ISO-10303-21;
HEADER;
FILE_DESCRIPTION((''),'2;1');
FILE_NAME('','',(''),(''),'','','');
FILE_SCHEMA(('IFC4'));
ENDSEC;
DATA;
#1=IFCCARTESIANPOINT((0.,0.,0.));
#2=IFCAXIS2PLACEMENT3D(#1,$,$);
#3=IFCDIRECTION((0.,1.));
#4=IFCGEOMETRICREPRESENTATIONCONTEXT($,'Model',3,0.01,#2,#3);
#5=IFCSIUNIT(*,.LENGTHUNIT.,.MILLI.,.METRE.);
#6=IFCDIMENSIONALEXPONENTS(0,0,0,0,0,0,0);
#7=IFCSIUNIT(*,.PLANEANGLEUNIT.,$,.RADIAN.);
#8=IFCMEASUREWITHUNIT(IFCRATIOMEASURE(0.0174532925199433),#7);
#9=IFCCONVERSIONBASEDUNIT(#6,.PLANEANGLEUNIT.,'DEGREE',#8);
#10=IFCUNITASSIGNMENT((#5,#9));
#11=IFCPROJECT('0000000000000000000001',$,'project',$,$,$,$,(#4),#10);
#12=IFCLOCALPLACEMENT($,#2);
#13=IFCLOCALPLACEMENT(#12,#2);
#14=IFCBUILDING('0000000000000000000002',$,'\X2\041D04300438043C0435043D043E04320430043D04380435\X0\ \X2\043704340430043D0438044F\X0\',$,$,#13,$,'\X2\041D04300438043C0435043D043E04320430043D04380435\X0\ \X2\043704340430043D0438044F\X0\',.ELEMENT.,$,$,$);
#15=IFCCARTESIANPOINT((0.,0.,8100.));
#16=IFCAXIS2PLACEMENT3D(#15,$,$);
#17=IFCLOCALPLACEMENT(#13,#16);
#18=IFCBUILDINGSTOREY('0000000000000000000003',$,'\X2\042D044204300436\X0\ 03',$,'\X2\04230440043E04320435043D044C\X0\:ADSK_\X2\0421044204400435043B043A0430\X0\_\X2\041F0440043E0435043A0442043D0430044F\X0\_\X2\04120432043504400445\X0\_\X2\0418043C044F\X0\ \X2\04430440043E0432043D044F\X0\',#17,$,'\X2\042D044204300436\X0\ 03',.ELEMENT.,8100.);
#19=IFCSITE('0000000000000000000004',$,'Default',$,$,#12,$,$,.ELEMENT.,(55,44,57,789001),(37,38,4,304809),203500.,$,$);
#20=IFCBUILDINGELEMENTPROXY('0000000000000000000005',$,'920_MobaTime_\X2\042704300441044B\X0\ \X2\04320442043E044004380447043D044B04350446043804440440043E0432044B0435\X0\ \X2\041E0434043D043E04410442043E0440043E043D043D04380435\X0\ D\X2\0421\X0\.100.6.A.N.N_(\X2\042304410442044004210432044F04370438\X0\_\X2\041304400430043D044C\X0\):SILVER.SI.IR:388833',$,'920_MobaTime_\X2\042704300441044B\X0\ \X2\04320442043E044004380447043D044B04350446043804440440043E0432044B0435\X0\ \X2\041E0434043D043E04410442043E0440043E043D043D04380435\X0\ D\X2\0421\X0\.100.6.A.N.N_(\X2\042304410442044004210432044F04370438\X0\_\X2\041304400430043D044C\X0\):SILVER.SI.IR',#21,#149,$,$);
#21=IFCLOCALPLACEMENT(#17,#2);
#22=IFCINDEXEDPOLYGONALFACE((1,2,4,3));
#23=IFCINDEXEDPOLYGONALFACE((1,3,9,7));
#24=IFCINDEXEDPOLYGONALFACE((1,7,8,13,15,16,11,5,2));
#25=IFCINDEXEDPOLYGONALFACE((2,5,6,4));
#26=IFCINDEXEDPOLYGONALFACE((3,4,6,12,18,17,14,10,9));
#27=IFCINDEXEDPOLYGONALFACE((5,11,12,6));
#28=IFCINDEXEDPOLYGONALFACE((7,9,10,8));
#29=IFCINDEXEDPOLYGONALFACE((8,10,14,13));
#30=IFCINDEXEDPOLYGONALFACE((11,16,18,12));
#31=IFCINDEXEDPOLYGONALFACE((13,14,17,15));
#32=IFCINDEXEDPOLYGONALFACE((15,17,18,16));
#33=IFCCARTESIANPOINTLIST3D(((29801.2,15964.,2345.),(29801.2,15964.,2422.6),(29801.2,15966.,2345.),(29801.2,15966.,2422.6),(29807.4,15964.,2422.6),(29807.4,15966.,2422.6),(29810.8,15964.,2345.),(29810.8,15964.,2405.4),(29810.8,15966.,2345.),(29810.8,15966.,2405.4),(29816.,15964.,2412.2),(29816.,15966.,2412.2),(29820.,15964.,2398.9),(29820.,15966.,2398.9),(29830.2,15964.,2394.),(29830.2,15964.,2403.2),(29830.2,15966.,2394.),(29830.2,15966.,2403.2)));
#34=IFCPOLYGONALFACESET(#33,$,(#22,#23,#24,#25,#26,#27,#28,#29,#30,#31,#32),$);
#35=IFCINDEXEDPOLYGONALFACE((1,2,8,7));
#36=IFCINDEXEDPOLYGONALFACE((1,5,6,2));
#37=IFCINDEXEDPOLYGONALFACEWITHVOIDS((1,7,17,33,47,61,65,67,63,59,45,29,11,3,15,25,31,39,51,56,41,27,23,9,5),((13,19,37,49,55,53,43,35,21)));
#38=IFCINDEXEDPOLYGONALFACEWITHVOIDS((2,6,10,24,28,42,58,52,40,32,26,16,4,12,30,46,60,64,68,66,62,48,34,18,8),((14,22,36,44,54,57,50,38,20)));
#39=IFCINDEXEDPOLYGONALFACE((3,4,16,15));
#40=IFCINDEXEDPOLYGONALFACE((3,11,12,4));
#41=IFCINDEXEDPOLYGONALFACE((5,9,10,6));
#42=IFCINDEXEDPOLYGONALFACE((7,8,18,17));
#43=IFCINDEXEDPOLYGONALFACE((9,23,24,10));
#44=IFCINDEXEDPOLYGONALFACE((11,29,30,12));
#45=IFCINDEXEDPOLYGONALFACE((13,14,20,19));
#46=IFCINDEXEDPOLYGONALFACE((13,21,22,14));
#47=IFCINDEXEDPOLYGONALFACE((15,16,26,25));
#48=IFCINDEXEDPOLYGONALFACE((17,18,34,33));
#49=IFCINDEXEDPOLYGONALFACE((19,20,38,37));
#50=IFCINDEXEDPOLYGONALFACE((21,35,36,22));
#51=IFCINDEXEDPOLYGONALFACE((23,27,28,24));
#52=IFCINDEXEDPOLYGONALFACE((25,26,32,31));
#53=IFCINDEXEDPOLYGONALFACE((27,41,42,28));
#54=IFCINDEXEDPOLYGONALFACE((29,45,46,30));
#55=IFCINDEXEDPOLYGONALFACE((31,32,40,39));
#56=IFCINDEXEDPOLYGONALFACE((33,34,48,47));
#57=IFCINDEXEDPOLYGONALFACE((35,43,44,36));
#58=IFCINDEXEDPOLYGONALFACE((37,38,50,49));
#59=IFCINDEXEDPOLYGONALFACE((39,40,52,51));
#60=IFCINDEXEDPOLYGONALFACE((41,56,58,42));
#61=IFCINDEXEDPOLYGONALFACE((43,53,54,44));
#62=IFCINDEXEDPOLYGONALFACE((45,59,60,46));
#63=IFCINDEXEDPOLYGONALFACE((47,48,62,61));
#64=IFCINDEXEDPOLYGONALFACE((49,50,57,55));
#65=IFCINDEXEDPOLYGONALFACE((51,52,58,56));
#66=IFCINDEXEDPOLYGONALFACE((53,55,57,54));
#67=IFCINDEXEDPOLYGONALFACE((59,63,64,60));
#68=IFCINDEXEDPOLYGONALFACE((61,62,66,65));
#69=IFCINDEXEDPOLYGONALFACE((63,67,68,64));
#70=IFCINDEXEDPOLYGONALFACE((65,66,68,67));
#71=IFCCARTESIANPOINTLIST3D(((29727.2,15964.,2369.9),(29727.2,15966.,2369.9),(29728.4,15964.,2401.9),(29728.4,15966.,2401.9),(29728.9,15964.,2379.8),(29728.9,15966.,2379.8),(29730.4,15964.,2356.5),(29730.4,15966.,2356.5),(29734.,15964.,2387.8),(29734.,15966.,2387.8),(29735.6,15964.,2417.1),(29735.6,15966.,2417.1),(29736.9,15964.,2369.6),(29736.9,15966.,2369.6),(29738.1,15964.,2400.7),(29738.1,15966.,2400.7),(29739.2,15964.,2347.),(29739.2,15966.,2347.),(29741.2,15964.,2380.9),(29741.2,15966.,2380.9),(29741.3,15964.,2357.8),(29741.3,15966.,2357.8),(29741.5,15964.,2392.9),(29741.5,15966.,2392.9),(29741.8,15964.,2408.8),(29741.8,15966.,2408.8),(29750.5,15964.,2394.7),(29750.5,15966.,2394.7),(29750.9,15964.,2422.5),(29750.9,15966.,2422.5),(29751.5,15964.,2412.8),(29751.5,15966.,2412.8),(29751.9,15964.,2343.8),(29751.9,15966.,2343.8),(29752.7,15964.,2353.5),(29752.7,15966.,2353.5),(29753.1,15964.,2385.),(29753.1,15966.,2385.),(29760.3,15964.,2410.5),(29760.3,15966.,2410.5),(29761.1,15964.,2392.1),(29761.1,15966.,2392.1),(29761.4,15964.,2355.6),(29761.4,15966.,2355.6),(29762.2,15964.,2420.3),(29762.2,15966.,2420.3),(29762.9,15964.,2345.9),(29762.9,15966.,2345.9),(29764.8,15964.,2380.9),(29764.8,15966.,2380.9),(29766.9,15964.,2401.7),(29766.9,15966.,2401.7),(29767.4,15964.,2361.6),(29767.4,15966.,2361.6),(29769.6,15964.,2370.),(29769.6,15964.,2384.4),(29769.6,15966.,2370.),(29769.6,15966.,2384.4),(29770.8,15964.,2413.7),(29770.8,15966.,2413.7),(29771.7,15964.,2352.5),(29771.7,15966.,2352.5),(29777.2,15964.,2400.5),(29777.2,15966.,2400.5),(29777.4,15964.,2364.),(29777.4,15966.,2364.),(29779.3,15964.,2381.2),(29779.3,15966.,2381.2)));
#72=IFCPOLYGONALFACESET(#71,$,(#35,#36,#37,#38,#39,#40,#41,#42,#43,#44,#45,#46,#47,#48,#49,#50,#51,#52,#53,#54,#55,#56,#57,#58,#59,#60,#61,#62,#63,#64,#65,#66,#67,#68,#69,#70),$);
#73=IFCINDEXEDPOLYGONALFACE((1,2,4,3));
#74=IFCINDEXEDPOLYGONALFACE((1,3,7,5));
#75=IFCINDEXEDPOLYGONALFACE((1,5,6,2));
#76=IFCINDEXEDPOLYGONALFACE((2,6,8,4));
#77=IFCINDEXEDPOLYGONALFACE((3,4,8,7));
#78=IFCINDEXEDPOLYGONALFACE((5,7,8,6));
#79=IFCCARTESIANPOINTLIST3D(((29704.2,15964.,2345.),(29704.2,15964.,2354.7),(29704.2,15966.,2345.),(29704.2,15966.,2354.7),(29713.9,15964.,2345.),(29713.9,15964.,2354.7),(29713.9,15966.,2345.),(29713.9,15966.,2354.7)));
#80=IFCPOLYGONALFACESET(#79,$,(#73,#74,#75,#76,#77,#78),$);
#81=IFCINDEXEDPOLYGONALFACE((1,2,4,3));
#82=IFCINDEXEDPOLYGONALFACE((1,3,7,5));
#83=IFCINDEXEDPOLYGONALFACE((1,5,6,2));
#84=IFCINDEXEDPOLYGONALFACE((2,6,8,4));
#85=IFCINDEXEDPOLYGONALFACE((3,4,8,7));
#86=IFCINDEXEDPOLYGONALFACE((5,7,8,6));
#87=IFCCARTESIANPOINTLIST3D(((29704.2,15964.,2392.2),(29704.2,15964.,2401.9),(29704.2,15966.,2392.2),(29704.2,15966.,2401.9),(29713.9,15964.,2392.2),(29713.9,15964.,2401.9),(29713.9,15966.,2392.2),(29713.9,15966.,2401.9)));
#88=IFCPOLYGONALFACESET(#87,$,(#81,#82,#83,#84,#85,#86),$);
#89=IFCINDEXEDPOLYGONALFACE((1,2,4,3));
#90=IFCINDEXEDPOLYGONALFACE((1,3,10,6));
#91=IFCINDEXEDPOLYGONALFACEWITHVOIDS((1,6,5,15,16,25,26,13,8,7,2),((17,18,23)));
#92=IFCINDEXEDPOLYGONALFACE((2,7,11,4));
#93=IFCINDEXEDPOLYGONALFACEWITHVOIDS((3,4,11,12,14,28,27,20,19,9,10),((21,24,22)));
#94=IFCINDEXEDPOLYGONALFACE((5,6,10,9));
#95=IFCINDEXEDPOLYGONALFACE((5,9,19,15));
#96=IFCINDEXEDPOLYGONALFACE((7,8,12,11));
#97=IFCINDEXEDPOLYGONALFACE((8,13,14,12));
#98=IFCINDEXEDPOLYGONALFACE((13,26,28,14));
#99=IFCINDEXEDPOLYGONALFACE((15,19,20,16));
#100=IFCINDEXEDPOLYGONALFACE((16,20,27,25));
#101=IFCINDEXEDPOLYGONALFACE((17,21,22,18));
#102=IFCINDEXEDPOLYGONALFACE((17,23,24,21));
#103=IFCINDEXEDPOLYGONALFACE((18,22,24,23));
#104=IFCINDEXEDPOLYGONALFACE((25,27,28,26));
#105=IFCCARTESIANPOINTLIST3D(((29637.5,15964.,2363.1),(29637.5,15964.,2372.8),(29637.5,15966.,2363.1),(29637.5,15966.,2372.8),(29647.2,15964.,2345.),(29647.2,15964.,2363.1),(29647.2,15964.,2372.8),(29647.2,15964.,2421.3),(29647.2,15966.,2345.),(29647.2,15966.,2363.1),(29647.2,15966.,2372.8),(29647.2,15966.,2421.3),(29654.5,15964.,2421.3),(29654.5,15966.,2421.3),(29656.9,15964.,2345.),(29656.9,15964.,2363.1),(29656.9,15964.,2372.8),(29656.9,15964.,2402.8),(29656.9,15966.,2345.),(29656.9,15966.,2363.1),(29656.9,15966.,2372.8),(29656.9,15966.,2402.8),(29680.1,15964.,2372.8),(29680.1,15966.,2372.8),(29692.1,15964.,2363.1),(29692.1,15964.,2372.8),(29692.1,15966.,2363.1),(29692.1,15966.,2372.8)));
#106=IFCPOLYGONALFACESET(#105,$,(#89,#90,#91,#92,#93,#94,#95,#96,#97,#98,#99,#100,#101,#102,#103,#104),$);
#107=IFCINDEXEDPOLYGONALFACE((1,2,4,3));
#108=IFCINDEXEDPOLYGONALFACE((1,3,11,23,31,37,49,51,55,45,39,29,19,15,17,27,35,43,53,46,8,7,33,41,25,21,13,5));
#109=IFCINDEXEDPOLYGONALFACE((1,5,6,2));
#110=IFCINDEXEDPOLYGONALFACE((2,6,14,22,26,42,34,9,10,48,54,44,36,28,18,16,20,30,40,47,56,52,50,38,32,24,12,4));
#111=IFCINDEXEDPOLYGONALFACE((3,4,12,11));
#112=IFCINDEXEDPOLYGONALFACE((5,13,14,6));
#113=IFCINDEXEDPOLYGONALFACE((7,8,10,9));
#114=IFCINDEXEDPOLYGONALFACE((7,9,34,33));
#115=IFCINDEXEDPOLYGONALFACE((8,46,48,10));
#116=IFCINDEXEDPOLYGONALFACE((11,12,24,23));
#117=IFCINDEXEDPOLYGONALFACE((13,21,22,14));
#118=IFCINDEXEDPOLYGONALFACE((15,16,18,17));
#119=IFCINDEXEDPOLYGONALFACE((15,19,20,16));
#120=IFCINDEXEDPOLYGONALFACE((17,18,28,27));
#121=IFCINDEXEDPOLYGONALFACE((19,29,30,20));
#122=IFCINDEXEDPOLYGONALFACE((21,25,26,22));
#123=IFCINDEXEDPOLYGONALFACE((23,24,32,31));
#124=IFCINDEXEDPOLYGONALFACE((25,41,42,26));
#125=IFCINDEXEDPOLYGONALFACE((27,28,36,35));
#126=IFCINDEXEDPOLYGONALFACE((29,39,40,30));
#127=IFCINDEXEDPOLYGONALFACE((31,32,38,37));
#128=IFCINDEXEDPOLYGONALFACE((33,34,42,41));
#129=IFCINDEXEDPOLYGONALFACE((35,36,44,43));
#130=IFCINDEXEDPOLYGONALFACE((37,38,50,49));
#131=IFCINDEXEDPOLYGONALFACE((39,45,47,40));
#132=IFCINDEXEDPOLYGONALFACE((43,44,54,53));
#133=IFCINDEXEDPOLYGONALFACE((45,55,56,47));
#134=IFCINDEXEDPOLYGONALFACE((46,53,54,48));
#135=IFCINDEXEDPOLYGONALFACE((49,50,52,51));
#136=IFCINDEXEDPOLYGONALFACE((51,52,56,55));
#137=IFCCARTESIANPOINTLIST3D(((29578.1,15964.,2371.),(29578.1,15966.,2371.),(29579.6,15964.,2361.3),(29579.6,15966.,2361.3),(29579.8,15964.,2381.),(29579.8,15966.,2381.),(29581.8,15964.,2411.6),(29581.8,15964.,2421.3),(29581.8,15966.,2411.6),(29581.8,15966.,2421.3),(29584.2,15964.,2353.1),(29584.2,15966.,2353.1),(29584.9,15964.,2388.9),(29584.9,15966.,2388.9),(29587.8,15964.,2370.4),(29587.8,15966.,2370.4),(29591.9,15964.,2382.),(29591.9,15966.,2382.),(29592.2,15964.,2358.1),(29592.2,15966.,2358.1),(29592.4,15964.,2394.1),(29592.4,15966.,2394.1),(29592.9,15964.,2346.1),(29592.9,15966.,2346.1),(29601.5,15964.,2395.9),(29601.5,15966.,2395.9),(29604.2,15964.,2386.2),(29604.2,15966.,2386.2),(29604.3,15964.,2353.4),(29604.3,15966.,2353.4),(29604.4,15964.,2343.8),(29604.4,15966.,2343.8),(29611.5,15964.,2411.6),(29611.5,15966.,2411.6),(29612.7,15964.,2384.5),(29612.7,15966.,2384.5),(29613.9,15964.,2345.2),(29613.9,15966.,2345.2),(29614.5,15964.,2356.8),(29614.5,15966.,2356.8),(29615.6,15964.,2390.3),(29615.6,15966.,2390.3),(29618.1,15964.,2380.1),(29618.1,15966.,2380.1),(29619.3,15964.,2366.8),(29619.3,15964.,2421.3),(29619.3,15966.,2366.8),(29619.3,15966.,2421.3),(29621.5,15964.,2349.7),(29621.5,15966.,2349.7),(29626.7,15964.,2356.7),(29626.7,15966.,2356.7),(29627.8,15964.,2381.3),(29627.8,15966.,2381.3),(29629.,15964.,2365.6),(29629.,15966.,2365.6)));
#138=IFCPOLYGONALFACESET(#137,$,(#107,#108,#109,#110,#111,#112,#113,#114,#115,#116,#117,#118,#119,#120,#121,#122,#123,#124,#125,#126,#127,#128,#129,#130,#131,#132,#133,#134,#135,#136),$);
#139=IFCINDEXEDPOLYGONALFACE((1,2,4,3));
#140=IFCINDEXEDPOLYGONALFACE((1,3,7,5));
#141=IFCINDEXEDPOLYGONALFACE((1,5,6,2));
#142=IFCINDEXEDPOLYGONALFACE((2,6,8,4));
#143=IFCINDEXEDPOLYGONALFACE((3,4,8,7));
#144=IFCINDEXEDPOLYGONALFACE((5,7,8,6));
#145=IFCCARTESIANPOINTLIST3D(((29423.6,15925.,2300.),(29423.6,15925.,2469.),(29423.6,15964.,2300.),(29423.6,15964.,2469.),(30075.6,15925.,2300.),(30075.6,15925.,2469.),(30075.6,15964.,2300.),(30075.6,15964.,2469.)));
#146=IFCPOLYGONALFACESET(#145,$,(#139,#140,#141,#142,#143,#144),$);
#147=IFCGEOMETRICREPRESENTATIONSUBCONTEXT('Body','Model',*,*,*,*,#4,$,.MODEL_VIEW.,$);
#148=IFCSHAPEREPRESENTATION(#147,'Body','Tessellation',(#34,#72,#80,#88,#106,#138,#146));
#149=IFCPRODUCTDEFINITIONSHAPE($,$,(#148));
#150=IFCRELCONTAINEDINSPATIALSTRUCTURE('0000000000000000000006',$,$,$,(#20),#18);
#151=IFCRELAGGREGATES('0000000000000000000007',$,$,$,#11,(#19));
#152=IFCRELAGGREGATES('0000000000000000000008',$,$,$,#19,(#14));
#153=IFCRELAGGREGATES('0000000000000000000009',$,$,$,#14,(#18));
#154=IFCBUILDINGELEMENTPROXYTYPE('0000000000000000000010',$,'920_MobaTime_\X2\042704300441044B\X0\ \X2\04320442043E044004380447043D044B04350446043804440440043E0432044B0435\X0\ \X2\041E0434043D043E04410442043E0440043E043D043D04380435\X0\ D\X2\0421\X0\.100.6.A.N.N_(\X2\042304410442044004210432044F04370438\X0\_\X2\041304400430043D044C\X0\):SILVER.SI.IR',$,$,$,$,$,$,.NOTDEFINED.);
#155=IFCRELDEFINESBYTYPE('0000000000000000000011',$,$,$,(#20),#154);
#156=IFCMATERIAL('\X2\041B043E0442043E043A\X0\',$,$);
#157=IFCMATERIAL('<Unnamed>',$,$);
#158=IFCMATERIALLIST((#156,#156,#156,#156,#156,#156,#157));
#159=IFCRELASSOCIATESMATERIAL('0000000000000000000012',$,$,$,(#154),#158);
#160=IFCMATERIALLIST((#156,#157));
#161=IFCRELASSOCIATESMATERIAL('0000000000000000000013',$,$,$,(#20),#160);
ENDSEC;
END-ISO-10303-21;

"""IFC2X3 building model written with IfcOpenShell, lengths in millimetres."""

from ifc_helpers import new_model, entity, si_unit, converted_unit, direction, frame, origin, origin_2d_with_axis, place, context, subcontext, project, spatial, polyline, rectangle, outline, extrude, source, transform, mapped, material, material_list, type_object, type_shapes, element, save


model = new_model("IFC2X3")

# Units and contexts
model_context = context("Model", 3, precision=0.01, world=origin(), true_north=direction((0.0, 1.0)))
body_context = subcontext(model_context, "Body", "Model", "MODEL_VIEW")
ifc_project = project(units=[si_unit("LENGTHUNIT", "METRE", prefix="MILLI"), converted_unit("PLANEANGLEUNIT", "DEGREE", entity("IfcRatioMeasure", 0.0174532925199433), si_unit("PLANEANGLEUNIT", "RADIAN"), dimensions=[0, 0, 0, 0, 0, 0, 0])], contexts=[model_context])

# Site, building, storey
site_placement = place(None, origin())
site = spatial("IfcSite", under=ifc_project, at=site_placement, Name="Default", CompositionType="ELEMENT", RefLatitude=(55, 44, 57, 789001), RefLongitude=(37, 38, 4, 304809), RefElevation=203500.0)
building_placement = place(site_placement, origin())
building = spatial("IfcBuilding", under=site, at=building_placement, Name="Наименование здания", LongName="Наименование здания", CompositionType="ELEMENT")
storey_placement = place(building_placement, frame((0.0, 0.0, 8100.0)))
storey = spatial("IfcBuildingStorey", under=building, at=storey_placement, Name="Этаж 03", ObjectType="Уровень:ADSK_Стрелка_Проектная_Вверх_Имя уровня", LongName="Этаж 03", CompositionType="ELEMENT", Elevation=8100.0)

# Building element proxy
ifc_material_1 = material(Name="Лоток")
ifc_material_2 = material(Name="<Unnamed>")
ifc_material_list_1 = material_list([ifc_material_1, ifc_material_1, ifc_material_1, ifc_material_1, ifc_material_1, ifc_material_1, ifc_material_2])
building_element_proxy_type = type_object("IfcBuildingElementProxyType", Name="920_MobaTime_Часы вторичныецифровые Односторонние DС.100.6.A.N.N_(УстрСвязи_Грань):SILVER.SI.IR", PredefinedType="NOTDEFINED", material=ifc_material_list_1)
shared_shape = source(origin(), body_context, "Body", "SweptSolid", [
    extrude(outline(polyline([(-49.3, -13.1), (28.2, -13.1), (28.2, -6.8), (17.9, 1.8), (8.8, 16.0), (-0.3, 16.0), (4.6, 5.8), (11.1, -3.4), (-49.3, -3.4), (-49.3, -13.1)])), frame((-64.6, 9.8, 39.0), z_axis=(0.0, 0.0, 1.0), x_axis=(0.0, 1.0, 0.0)), (0.0, 0.0, 1.0), 2.0),
    extrude(outline(polyline([(2.2, -27.6), (19.0, -27.6), (30.5, -16.1), (33.3, -4.9), (31.0, 5.8), (21.8, 17.2), (5.2, 27.3), (-11.1, 33.0), (-24.0, 32.7), (-33.6, 27.6), (-40.3, 18.6), (-42.8, 5.7), (-38.0, -6.3), (-27.2, -14.9), (-17.5, -17.7), (-8.2, -16.4), (-0.3, -11.9), (5.1, -4.5), (7.3, 6.2), (4.0, 17.2), (18.4, 7.3), (23.6, -2.4), (22.0, -11.4), (14.2, -18.4), (5.3, -18.3), (2.2, -27.6)]), holes=[polyline([(-9.0, 23.3), (-1.3, 14.3), (-2.5, 2.0), (-11.4, -7.0), (-23.4, -6.0), (-32.2, 2.9), (-31.2, 15.1), (-25.6, 22.1), (-17.5, 24.9), (-9.0, 23.3)])]), frame((-2.7, 3.6, 39.0), z_axis=(0.0, 0.0, 1.0), x_axis=(-0.427649, 0.903945, 0.0)), (0.0, 0.0, 1.0), 2.0),
    extrude(rectangle(XDim=9.7, YDim=9.7, at=origin_2d_with_axis()), frame((40.6, -34.7, 39.0)), (0.0, 0.0, 1.0), 2.0),
    extrude(rectangle(XDim=9.7, YDim=9.7, at=origin_2d_with_axis()), frame((40.6, 12.6, 39.0)), (0.0, 0.0, 1.0), 2.0),
    extrude(outline(polyline([(-0.9, -28.1), (8.8, -28.1), (8.8, -9.9), (18.5, -9.9), (18.5, -0.2), (8.8, -0.2), (8.8, 48.3), (1.5, 48.3), (-36.0, -0.2), (-36.0, -9.9), (-0.9, -9.9), (-0.9, -28.1)]), holes=[polyline([(-0.9, -0.2), (-24.1, -0.2), (-0.9, 29.7), (-0.9, -0.2)])]), frame((93.6, -11.4, 39.0)), (0.0, 0.0, 1.0), 2.0),
    extrude(outline(polyline([(3.3, -28.3), (12.5, -28.3), (20.5, -25.0), (26.8, -18.9), (30.7, -10.0), (31.4, 1.6), (26.9, 11.8), (20.1, 18.4), (11.1, 22.3), (1.0, 23.3), (-7.9, 20.4), (-14.9, 14.5), (-18.9, 6.2), (-17.1, -9.0), (-36.7, 0.5), (-29.1, 29.2), (-38.5, 31.7), (-48.1, -4.6), (-11.6, -23.1), (-8.0, -14.0), (-10.8, -7.6), (-10.2, 1.1), (-3.0, 11.8), (9.2, 12.8), (20.0, 5.5), (21.4, -7.5), (15.5, -16.4), (4.6, -18.6), (3.3, -28.3)])), frame((147.1, -8.5, 39.0), z_axis=(0.0, 0.0, 1.0), x_axis=(0.256974, -0.966418, 0.0)), (0.0, 0.0, 1.0), 2.0),
    extrude(rectangle(XDim=652.0, YDim=169.0, at=origin_2d_with_axis()), frame((0.0, 0.0, 0.0), z_axis=(0.0, 0.0, 1.0), x_axis=(-1.0, 0.0, 0.0)), (0.0, 0.0, 1.0), 39.0),
])
type_shapes(building_element_proxy_type, [shared_shape])
ifc_material_list_2 = material_list([ifc_material_1, ifc_material_2])
for number, where, z_axis, x_axis, name in (
    (1, (29749.6, 15925.0, 2384.5), (0.0, 1.0, 0.0), (-1.0, 0.0, 0.0), "920_MobaTime_Часы вторичныецифровые Односторонние DС.100.6.A.N.N_(УстрСвязи_Грань):SILVER.SI.IR:388833"),
):
    element("IfcBuildingElementProxy", number, at=place(storey_placement, frame(where, z_axis=z_axis, x_axis=x_axis)), inside=storey, type_object=building_element_proxy_type, material=ifc_material_list_2, Name=name, ObjectType="920_MobaTime_Часы вторичныецифровые Односторонние DС.100.6.A.N.N_(УстрСвязи_Грань):SILVER.SI.IR", context=body_context, shape_type="MappedRepresentation", body=[
        mapped(shared_shape, transform((0.0, 0.0, 0.0), scale=1.0)),
    ])

save(model, "model.ifc")
